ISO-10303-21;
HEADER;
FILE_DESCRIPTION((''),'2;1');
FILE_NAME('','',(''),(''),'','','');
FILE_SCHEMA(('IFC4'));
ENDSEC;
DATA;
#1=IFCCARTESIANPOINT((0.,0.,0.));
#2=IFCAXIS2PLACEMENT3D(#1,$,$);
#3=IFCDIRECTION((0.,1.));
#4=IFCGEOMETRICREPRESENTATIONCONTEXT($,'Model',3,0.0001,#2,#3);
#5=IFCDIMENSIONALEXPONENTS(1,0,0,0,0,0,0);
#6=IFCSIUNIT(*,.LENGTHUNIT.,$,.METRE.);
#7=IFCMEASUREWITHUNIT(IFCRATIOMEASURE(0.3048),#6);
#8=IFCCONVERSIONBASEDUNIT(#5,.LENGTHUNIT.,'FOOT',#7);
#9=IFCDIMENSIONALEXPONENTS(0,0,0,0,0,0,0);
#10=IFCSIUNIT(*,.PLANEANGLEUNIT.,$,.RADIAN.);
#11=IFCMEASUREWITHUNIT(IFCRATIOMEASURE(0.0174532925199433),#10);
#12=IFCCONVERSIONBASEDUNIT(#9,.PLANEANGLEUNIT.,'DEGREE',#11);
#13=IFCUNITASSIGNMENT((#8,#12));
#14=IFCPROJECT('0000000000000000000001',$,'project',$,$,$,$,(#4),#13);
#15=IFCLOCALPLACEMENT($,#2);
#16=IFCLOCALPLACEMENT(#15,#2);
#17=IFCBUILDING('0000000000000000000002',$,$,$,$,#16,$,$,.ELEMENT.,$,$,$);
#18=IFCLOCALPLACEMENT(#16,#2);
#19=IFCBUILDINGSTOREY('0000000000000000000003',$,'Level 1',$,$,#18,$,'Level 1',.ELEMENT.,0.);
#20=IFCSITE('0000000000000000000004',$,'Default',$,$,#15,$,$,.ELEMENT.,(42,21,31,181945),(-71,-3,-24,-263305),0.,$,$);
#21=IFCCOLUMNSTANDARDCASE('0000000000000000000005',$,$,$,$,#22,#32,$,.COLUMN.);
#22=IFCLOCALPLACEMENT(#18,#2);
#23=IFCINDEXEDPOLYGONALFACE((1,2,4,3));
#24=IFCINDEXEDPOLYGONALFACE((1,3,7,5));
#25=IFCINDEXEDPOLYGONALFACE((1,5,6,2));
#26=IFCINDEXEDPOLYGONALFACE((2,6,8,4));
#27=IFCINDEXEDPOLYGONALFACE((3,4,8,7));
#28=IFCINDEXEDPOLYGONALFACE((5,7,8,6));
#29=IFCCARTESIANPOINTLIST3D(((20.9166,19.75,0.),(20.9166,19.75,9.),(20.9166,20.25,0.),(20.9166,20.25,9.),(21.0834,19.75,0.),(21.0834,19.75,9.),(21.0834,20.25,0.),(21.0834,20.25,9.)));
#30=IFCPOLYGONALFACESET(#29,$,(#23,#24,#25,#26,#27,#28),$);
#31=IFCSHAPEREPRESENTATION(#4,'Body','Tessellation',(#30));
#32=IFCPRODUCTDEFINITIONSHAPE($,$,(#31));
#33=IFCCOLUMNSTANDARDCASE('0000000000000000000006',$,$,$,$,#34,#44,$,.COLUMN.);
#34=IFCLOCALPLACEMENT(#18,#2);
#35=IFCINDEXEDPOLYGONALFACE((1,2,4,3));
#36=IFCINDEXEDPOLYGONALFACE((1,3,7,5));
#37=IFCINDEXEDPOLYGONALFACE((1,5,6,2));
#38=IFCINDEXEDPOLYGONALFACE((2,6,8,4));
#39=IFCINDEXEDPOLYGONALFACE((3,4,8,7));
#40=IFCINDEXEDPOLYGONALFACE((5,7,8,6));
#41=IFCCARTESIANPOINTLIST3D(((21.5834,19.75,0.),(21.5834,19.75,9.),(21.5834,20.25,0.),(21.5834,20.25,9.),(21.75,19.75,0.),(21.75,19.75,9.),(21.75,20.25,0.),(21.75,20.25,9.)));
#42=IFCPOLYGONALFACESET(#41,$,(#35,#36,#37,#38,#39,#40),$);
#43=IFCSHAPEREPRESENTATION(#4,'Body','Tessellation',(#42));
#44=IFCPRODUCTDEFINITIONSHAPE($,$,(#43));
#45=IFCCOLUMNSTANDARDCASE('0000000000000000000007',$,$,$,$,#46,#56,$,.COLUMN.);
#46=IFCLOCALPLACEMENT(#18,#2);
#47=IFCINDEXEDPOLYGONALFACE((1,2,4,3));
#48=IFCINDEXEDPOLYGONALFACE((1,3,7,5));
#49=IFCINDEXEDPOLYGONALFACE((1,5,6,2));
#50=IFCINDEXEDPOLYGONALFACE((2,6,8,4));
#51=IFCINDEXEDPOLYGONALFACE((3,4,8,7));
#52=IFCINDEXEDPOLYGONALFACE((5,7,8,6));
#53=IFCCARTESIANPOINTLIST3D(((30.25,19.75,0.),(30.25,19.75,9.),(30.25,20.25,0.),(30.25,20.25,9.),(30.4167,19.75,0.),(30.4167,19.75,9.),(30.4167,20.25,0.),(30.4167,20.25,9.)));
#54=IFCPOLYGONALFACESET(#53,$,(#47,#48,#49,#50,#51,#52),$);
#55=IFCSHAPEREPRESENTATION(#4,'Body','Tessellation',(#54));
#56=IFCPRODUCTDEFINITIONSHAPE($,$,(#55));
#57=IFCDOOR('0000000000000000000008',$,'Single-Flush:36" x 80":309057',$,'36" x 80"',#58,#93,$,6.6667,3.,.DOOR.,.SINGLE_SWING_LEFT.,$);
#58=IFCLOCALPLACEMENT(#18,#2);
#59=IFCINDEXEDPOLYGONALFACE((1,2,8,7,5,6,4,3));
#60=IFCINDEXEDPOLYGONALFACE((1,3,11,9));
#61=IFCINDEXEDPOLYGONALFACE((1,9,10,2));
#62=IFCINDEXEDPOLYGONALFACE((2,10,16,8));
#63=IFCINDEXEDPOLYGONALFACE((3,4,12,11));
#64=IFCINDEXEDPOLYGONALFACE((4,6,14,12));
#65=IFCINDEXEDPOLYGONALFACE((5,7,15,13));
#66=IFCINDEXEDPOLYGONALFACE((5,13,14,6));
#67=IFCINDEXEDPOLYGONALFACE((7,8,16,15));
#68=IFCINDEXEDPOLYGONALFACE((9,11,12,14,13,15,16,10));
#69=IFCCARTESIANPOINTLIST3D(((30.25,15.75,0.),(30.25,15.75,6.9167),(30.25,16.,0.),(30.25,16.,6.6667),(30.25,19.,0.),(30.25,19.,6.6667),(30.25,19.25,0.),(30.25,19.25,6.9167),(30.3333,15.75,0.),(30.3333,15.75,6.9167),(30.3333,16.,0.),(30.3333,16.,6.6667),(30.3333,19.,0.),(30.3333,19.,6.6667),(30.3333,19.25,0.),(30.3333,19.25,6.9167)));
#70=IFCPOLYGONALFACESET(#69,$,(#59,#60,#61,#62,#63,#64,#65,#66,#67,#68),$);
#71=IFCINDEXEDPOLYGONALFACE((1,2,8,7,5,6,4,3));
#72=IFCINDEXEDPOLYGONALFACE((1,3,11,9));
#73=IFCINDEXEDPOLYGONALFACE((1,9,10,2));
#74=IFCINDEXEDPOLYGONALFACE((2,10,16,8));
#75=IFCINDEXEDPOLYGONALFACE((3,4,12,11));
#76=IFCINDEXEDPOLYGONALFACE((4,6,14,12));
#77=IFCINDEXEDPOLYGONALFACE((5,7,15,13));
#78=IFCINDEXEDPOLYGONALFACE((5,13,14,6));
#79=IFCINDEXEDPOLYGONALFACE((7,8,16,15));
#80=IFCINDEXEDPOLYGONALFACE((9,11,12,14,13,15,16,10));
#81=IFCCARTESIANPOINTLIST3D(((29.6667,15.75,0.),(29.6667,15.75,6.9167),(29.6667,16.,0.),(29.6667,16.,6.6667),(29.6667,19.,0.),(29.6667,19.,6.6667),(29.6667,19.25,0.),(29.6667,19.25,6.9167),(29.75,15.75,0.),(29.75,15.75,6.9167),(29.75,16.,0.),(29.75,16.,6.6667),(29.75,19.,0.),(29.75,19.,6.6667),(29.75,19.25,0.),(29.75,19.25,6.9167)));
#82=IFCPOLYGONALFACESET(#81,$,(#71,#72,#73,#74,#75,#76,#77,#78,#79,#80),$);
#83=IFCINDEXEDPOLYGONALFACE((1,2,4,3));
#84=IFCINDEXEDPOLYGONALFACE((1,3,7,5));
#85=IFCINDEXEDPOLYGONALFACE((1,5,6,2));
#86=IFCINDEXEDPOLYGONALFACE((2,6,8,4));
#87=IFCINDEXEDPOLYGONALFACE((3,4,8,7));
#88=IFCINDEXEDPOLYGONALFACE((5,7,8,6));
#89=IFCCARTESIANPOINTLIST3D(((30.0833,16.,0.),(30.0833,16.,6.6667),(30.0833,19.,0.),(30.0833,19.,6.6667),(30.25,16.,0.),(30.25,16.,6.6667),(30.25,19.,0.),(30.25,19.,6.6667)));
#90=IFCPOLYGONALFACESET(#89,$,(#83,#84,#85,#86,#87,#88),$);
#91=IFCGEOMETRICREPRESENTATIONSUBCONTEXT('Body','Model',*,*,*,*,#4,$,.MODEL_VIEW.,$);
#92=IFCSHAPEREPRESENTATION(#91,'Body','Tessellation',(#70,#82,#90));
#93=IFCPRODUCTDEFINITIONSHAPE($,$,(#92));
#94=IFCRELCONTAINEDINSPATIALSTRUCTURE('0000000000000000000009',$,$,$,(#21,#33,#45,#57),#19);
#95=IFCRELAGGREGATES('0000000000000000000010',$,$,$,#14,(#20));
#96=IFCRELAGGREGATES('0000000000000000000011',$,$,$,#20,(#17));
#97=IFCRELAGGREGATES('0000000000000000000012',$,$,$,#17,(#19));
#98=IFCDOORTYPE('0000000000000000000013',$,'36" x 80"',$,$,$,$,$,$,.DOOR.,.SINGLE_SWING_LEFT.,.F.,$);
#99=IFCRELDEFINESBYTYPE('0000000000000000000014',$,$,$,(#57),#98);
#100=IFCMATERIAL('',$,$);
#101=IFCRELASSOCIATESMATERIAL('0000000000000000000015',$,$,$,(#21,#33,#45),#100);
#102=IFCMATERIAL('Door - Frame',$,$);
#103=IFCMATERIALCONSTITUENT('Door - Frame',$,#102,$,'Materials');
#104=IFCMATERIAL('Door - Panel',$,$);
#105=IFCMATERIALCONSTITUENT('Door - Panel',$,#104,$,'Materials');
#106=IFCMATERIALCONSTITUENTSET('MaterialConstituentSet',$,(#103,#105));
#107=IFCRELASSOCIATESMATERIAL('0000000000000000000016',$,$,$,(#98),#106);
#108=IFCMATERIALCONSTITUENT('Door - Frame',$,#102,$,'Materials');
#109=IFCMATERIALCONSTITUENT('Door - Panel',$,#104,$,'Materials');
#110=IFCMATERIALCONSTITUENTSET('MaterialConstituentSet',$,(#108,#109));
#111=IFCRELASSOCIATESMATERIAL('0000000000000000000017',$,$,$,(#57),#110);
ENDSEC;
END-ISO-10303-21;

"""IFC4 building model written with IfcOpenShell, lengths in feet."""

from ifc_helpers import new_model, entity, si_unit, converted_unit, direction, frame, origin, origin_2d_with_axis, place, context, subcontext, project, spatial, polyline, rectangle, outline, extrude, source, transform, mapped, material, constituent, constituent_set, type_object, type_shapes, element, save


model = new_model("IFC4")

# Units and contexts
model_context = context("Model", 3, precision=0.0001, world=origin(), true_north=direction((0.0, 1.0)))
body_context = subcontext(model_context, "Body", "Model", "MODEL_VIEW")
ifc_project = project(units=[converted_unit("LENGTHUNIT", "FOOT", entity("IfcRatioMeasure", 0.3048), si_unit("LENGTHUNIT", "METRE"), dimensions=[1, 0, 0, 0, 0, 0, 0]), converted_unit("PLANEANGLEUNIT", "DEGREE", entity("IfcRatioMeasure", 0.0174532925199433), si_unit("PLANEANGLEUNIT", "RADIAN"), dimensions=[0, 0, 0, 0, 0, 0, 0])], contexts=[model_context])

# Site, building, storey
site_placement = place(None, origin())
site = spatial("IfcSite", under=ifc_project, at=site_placement, Name="Default", CompositionType="ELEMENT", RefLatitude=(42, 21, 31, 181945), RefLongitude=(-71, -3, -24, -263305), RefElevation=0.0)
building_placement = place(site_placement, origin())
building = spatial("IfcBuilding", under=site, at=building_placement, CompositionType="ELEMENT")
storey_placement = place(building_placement, origin())
storey = spatial("IfcBuildingStorey", under=building, at=storey_placement, Name="Level 1", LongName="Level 1", CompositionType="ELEMENT", Elevation=0.0)

# Columns
ifc_material_1 = material(Name="")
placement_1 = place(storey_placement, frame((0.25, 20.0, 0.0)))
for number, where, z_axis, x_axis in (
    (1, (20.75, 0.0, 0.0), (0.0, 0.0, 1.0), (1.0, 0.0, 0.0)),
    (2, (21.4167, 0.0, 0.0), (0.0, 0.0, 1.0), (1.0, 0.0, 0.0)),
):
    element("IfcColumnStandardCase", number, at=place(placement_1, frame(where, z_axis=z_axis, x_axis=x_axis)), inside=storey, material=ifc_material_1, PredefinedType="COLUMN", context=model_context, shape_type="SweptSolid", body=[
        extrude(rectangle(XDim=0.1667, YDim=0.5), origin(), (0.0, 0.0, 1.0), 9.0),
    ])
placement_2 = place(storey_placement, frame((30.0, 45.75, 0.0), z_axis=(0.0, 0.0, 1.0), x_axis=(0.0, -1.0, 0.0)))
placement_3 = place(storey_placement, frame((30.25, 20.0, 0.0)))
for number, where, z_axis, x_axis in (
    (3, (0.0833, 0.0, 0.0), (0.0, 0.0, 1.0), (1.0, 0.0, 0.0)),
):
    element("IfcColumnStandardCase", number, at=place(placement_3, frame(where, z_axis=z_axis, x_axis=x_axis)), inside=storey, material=ifc_material_1, PredefinedType="COLUMN", context=model_context, shape_type="SweptSolid", body=[
        extrude(rectangle(XDim=0.1667, YDim=0.5), origin(), (0.0, 0.0, 1.0), 9.0),
    ])

# Door
ifc_material_2 = material(Name="Door - Frame")
ifc_constituent_1 = constituent(ifc_material_2, Name="Door - Frame", Category="Materials")
ifc_material_3 = material(Name="Door - Panel")
ifc_constituent_2 = constituent(ifc_material_3, Name="Door - Panel", Category="Materials")
ifc_constituent_set_1 = constituent_set(constituents=[ifc_constituent_1, ifc_constituent_2], Name="MaterialConstituentSet")
ifc_constituent_3 = constituent(ifc_material_2, Name="Door - Frame", Category="Materials")
ifc_constituent_4 = constituent(ifc_material_3, Name="Door - Panel", Category="Materials")
ifc_constituent_set_2 = constituent_set(constituents=[ifc_constituent_3, ifc_constituent_4], Name="MaterialConstituentSet")
door_type = type_object("IfcDoorType", Name="36\" x 80\"", OperationType="SINGLE_SWING_LEFT", ParameterTakesPrecedence=False, PredefinedType="DOOR", material=ifc_constituent_set_2)
shared_shape = source(origin(), body_context, "Body", "SweptSolid", [
    extrude(outline(polyline([(-1.75, -3.5208), (1.75, -3.5208), (1.75, 3.3958), (1.5, 3.3958), (1.5, -3.2708), (-1.5, -3.2708), (-1.5, 3.3958), (-1.75, 3.3958), (-1.75, -3.5208)])), frame((1.5, 0.5833, 3.3958), z_axis=(0.0, -1.0, 0.0), x_axis=(-1.0, 0.0, 0.0)), (0.0, 0.0, 1.0), 0.0833),
    extrude(outline(polyline([(-3.5208, -1.75), (3.3958, -1.75), (3.3958, -1.5), (-3.2708, -1.5), (-3.2708, 1.5), (3.3958, 1.5), (3.3958, 1.75), (-3.5208, 1.75), (-3.5208, -1.75)])), frame((1.5, 0.0, 3.3958), z_axis=(0.0, -1.0, 0.0), x_axis=(0.0, 0.0, -1.0)), (0.0, 0.0, 1.0), 0.0833),
    extrude(rectangle(XDim=3.0, YDim=0.1667, at=origin_2d_with_axis()), frame((1.5, 0.4167, 0.0)), (0.0, 0.0, 1.0), 6.6667),
])
type_shapes(door_type, [shared_shape])
placement_4 = place(placement_2, frame((26.75, -0.25, 0.0)))
door_placement = place(placement_4, origin())
element("IfcDoor", 4, at=door_placement, inside=storey, type_object=door_type, material=ifc_constituent_set_1, Name="Single-Flush:36\" x 80\":309057", ObjectType="36\" x 80\"", OperationType="SINGLE_SWING_LEFT", OverallHeight=6.6667, OverallWidth=3.0, PredefinedType="DOOR", context=body_context, shape_type="MappedRepresentation", body=[
    mapped(shared_shape, transform((0.0, 0.0, 0.0), scale=1.0)),
])

save(model, "model.ifc")
